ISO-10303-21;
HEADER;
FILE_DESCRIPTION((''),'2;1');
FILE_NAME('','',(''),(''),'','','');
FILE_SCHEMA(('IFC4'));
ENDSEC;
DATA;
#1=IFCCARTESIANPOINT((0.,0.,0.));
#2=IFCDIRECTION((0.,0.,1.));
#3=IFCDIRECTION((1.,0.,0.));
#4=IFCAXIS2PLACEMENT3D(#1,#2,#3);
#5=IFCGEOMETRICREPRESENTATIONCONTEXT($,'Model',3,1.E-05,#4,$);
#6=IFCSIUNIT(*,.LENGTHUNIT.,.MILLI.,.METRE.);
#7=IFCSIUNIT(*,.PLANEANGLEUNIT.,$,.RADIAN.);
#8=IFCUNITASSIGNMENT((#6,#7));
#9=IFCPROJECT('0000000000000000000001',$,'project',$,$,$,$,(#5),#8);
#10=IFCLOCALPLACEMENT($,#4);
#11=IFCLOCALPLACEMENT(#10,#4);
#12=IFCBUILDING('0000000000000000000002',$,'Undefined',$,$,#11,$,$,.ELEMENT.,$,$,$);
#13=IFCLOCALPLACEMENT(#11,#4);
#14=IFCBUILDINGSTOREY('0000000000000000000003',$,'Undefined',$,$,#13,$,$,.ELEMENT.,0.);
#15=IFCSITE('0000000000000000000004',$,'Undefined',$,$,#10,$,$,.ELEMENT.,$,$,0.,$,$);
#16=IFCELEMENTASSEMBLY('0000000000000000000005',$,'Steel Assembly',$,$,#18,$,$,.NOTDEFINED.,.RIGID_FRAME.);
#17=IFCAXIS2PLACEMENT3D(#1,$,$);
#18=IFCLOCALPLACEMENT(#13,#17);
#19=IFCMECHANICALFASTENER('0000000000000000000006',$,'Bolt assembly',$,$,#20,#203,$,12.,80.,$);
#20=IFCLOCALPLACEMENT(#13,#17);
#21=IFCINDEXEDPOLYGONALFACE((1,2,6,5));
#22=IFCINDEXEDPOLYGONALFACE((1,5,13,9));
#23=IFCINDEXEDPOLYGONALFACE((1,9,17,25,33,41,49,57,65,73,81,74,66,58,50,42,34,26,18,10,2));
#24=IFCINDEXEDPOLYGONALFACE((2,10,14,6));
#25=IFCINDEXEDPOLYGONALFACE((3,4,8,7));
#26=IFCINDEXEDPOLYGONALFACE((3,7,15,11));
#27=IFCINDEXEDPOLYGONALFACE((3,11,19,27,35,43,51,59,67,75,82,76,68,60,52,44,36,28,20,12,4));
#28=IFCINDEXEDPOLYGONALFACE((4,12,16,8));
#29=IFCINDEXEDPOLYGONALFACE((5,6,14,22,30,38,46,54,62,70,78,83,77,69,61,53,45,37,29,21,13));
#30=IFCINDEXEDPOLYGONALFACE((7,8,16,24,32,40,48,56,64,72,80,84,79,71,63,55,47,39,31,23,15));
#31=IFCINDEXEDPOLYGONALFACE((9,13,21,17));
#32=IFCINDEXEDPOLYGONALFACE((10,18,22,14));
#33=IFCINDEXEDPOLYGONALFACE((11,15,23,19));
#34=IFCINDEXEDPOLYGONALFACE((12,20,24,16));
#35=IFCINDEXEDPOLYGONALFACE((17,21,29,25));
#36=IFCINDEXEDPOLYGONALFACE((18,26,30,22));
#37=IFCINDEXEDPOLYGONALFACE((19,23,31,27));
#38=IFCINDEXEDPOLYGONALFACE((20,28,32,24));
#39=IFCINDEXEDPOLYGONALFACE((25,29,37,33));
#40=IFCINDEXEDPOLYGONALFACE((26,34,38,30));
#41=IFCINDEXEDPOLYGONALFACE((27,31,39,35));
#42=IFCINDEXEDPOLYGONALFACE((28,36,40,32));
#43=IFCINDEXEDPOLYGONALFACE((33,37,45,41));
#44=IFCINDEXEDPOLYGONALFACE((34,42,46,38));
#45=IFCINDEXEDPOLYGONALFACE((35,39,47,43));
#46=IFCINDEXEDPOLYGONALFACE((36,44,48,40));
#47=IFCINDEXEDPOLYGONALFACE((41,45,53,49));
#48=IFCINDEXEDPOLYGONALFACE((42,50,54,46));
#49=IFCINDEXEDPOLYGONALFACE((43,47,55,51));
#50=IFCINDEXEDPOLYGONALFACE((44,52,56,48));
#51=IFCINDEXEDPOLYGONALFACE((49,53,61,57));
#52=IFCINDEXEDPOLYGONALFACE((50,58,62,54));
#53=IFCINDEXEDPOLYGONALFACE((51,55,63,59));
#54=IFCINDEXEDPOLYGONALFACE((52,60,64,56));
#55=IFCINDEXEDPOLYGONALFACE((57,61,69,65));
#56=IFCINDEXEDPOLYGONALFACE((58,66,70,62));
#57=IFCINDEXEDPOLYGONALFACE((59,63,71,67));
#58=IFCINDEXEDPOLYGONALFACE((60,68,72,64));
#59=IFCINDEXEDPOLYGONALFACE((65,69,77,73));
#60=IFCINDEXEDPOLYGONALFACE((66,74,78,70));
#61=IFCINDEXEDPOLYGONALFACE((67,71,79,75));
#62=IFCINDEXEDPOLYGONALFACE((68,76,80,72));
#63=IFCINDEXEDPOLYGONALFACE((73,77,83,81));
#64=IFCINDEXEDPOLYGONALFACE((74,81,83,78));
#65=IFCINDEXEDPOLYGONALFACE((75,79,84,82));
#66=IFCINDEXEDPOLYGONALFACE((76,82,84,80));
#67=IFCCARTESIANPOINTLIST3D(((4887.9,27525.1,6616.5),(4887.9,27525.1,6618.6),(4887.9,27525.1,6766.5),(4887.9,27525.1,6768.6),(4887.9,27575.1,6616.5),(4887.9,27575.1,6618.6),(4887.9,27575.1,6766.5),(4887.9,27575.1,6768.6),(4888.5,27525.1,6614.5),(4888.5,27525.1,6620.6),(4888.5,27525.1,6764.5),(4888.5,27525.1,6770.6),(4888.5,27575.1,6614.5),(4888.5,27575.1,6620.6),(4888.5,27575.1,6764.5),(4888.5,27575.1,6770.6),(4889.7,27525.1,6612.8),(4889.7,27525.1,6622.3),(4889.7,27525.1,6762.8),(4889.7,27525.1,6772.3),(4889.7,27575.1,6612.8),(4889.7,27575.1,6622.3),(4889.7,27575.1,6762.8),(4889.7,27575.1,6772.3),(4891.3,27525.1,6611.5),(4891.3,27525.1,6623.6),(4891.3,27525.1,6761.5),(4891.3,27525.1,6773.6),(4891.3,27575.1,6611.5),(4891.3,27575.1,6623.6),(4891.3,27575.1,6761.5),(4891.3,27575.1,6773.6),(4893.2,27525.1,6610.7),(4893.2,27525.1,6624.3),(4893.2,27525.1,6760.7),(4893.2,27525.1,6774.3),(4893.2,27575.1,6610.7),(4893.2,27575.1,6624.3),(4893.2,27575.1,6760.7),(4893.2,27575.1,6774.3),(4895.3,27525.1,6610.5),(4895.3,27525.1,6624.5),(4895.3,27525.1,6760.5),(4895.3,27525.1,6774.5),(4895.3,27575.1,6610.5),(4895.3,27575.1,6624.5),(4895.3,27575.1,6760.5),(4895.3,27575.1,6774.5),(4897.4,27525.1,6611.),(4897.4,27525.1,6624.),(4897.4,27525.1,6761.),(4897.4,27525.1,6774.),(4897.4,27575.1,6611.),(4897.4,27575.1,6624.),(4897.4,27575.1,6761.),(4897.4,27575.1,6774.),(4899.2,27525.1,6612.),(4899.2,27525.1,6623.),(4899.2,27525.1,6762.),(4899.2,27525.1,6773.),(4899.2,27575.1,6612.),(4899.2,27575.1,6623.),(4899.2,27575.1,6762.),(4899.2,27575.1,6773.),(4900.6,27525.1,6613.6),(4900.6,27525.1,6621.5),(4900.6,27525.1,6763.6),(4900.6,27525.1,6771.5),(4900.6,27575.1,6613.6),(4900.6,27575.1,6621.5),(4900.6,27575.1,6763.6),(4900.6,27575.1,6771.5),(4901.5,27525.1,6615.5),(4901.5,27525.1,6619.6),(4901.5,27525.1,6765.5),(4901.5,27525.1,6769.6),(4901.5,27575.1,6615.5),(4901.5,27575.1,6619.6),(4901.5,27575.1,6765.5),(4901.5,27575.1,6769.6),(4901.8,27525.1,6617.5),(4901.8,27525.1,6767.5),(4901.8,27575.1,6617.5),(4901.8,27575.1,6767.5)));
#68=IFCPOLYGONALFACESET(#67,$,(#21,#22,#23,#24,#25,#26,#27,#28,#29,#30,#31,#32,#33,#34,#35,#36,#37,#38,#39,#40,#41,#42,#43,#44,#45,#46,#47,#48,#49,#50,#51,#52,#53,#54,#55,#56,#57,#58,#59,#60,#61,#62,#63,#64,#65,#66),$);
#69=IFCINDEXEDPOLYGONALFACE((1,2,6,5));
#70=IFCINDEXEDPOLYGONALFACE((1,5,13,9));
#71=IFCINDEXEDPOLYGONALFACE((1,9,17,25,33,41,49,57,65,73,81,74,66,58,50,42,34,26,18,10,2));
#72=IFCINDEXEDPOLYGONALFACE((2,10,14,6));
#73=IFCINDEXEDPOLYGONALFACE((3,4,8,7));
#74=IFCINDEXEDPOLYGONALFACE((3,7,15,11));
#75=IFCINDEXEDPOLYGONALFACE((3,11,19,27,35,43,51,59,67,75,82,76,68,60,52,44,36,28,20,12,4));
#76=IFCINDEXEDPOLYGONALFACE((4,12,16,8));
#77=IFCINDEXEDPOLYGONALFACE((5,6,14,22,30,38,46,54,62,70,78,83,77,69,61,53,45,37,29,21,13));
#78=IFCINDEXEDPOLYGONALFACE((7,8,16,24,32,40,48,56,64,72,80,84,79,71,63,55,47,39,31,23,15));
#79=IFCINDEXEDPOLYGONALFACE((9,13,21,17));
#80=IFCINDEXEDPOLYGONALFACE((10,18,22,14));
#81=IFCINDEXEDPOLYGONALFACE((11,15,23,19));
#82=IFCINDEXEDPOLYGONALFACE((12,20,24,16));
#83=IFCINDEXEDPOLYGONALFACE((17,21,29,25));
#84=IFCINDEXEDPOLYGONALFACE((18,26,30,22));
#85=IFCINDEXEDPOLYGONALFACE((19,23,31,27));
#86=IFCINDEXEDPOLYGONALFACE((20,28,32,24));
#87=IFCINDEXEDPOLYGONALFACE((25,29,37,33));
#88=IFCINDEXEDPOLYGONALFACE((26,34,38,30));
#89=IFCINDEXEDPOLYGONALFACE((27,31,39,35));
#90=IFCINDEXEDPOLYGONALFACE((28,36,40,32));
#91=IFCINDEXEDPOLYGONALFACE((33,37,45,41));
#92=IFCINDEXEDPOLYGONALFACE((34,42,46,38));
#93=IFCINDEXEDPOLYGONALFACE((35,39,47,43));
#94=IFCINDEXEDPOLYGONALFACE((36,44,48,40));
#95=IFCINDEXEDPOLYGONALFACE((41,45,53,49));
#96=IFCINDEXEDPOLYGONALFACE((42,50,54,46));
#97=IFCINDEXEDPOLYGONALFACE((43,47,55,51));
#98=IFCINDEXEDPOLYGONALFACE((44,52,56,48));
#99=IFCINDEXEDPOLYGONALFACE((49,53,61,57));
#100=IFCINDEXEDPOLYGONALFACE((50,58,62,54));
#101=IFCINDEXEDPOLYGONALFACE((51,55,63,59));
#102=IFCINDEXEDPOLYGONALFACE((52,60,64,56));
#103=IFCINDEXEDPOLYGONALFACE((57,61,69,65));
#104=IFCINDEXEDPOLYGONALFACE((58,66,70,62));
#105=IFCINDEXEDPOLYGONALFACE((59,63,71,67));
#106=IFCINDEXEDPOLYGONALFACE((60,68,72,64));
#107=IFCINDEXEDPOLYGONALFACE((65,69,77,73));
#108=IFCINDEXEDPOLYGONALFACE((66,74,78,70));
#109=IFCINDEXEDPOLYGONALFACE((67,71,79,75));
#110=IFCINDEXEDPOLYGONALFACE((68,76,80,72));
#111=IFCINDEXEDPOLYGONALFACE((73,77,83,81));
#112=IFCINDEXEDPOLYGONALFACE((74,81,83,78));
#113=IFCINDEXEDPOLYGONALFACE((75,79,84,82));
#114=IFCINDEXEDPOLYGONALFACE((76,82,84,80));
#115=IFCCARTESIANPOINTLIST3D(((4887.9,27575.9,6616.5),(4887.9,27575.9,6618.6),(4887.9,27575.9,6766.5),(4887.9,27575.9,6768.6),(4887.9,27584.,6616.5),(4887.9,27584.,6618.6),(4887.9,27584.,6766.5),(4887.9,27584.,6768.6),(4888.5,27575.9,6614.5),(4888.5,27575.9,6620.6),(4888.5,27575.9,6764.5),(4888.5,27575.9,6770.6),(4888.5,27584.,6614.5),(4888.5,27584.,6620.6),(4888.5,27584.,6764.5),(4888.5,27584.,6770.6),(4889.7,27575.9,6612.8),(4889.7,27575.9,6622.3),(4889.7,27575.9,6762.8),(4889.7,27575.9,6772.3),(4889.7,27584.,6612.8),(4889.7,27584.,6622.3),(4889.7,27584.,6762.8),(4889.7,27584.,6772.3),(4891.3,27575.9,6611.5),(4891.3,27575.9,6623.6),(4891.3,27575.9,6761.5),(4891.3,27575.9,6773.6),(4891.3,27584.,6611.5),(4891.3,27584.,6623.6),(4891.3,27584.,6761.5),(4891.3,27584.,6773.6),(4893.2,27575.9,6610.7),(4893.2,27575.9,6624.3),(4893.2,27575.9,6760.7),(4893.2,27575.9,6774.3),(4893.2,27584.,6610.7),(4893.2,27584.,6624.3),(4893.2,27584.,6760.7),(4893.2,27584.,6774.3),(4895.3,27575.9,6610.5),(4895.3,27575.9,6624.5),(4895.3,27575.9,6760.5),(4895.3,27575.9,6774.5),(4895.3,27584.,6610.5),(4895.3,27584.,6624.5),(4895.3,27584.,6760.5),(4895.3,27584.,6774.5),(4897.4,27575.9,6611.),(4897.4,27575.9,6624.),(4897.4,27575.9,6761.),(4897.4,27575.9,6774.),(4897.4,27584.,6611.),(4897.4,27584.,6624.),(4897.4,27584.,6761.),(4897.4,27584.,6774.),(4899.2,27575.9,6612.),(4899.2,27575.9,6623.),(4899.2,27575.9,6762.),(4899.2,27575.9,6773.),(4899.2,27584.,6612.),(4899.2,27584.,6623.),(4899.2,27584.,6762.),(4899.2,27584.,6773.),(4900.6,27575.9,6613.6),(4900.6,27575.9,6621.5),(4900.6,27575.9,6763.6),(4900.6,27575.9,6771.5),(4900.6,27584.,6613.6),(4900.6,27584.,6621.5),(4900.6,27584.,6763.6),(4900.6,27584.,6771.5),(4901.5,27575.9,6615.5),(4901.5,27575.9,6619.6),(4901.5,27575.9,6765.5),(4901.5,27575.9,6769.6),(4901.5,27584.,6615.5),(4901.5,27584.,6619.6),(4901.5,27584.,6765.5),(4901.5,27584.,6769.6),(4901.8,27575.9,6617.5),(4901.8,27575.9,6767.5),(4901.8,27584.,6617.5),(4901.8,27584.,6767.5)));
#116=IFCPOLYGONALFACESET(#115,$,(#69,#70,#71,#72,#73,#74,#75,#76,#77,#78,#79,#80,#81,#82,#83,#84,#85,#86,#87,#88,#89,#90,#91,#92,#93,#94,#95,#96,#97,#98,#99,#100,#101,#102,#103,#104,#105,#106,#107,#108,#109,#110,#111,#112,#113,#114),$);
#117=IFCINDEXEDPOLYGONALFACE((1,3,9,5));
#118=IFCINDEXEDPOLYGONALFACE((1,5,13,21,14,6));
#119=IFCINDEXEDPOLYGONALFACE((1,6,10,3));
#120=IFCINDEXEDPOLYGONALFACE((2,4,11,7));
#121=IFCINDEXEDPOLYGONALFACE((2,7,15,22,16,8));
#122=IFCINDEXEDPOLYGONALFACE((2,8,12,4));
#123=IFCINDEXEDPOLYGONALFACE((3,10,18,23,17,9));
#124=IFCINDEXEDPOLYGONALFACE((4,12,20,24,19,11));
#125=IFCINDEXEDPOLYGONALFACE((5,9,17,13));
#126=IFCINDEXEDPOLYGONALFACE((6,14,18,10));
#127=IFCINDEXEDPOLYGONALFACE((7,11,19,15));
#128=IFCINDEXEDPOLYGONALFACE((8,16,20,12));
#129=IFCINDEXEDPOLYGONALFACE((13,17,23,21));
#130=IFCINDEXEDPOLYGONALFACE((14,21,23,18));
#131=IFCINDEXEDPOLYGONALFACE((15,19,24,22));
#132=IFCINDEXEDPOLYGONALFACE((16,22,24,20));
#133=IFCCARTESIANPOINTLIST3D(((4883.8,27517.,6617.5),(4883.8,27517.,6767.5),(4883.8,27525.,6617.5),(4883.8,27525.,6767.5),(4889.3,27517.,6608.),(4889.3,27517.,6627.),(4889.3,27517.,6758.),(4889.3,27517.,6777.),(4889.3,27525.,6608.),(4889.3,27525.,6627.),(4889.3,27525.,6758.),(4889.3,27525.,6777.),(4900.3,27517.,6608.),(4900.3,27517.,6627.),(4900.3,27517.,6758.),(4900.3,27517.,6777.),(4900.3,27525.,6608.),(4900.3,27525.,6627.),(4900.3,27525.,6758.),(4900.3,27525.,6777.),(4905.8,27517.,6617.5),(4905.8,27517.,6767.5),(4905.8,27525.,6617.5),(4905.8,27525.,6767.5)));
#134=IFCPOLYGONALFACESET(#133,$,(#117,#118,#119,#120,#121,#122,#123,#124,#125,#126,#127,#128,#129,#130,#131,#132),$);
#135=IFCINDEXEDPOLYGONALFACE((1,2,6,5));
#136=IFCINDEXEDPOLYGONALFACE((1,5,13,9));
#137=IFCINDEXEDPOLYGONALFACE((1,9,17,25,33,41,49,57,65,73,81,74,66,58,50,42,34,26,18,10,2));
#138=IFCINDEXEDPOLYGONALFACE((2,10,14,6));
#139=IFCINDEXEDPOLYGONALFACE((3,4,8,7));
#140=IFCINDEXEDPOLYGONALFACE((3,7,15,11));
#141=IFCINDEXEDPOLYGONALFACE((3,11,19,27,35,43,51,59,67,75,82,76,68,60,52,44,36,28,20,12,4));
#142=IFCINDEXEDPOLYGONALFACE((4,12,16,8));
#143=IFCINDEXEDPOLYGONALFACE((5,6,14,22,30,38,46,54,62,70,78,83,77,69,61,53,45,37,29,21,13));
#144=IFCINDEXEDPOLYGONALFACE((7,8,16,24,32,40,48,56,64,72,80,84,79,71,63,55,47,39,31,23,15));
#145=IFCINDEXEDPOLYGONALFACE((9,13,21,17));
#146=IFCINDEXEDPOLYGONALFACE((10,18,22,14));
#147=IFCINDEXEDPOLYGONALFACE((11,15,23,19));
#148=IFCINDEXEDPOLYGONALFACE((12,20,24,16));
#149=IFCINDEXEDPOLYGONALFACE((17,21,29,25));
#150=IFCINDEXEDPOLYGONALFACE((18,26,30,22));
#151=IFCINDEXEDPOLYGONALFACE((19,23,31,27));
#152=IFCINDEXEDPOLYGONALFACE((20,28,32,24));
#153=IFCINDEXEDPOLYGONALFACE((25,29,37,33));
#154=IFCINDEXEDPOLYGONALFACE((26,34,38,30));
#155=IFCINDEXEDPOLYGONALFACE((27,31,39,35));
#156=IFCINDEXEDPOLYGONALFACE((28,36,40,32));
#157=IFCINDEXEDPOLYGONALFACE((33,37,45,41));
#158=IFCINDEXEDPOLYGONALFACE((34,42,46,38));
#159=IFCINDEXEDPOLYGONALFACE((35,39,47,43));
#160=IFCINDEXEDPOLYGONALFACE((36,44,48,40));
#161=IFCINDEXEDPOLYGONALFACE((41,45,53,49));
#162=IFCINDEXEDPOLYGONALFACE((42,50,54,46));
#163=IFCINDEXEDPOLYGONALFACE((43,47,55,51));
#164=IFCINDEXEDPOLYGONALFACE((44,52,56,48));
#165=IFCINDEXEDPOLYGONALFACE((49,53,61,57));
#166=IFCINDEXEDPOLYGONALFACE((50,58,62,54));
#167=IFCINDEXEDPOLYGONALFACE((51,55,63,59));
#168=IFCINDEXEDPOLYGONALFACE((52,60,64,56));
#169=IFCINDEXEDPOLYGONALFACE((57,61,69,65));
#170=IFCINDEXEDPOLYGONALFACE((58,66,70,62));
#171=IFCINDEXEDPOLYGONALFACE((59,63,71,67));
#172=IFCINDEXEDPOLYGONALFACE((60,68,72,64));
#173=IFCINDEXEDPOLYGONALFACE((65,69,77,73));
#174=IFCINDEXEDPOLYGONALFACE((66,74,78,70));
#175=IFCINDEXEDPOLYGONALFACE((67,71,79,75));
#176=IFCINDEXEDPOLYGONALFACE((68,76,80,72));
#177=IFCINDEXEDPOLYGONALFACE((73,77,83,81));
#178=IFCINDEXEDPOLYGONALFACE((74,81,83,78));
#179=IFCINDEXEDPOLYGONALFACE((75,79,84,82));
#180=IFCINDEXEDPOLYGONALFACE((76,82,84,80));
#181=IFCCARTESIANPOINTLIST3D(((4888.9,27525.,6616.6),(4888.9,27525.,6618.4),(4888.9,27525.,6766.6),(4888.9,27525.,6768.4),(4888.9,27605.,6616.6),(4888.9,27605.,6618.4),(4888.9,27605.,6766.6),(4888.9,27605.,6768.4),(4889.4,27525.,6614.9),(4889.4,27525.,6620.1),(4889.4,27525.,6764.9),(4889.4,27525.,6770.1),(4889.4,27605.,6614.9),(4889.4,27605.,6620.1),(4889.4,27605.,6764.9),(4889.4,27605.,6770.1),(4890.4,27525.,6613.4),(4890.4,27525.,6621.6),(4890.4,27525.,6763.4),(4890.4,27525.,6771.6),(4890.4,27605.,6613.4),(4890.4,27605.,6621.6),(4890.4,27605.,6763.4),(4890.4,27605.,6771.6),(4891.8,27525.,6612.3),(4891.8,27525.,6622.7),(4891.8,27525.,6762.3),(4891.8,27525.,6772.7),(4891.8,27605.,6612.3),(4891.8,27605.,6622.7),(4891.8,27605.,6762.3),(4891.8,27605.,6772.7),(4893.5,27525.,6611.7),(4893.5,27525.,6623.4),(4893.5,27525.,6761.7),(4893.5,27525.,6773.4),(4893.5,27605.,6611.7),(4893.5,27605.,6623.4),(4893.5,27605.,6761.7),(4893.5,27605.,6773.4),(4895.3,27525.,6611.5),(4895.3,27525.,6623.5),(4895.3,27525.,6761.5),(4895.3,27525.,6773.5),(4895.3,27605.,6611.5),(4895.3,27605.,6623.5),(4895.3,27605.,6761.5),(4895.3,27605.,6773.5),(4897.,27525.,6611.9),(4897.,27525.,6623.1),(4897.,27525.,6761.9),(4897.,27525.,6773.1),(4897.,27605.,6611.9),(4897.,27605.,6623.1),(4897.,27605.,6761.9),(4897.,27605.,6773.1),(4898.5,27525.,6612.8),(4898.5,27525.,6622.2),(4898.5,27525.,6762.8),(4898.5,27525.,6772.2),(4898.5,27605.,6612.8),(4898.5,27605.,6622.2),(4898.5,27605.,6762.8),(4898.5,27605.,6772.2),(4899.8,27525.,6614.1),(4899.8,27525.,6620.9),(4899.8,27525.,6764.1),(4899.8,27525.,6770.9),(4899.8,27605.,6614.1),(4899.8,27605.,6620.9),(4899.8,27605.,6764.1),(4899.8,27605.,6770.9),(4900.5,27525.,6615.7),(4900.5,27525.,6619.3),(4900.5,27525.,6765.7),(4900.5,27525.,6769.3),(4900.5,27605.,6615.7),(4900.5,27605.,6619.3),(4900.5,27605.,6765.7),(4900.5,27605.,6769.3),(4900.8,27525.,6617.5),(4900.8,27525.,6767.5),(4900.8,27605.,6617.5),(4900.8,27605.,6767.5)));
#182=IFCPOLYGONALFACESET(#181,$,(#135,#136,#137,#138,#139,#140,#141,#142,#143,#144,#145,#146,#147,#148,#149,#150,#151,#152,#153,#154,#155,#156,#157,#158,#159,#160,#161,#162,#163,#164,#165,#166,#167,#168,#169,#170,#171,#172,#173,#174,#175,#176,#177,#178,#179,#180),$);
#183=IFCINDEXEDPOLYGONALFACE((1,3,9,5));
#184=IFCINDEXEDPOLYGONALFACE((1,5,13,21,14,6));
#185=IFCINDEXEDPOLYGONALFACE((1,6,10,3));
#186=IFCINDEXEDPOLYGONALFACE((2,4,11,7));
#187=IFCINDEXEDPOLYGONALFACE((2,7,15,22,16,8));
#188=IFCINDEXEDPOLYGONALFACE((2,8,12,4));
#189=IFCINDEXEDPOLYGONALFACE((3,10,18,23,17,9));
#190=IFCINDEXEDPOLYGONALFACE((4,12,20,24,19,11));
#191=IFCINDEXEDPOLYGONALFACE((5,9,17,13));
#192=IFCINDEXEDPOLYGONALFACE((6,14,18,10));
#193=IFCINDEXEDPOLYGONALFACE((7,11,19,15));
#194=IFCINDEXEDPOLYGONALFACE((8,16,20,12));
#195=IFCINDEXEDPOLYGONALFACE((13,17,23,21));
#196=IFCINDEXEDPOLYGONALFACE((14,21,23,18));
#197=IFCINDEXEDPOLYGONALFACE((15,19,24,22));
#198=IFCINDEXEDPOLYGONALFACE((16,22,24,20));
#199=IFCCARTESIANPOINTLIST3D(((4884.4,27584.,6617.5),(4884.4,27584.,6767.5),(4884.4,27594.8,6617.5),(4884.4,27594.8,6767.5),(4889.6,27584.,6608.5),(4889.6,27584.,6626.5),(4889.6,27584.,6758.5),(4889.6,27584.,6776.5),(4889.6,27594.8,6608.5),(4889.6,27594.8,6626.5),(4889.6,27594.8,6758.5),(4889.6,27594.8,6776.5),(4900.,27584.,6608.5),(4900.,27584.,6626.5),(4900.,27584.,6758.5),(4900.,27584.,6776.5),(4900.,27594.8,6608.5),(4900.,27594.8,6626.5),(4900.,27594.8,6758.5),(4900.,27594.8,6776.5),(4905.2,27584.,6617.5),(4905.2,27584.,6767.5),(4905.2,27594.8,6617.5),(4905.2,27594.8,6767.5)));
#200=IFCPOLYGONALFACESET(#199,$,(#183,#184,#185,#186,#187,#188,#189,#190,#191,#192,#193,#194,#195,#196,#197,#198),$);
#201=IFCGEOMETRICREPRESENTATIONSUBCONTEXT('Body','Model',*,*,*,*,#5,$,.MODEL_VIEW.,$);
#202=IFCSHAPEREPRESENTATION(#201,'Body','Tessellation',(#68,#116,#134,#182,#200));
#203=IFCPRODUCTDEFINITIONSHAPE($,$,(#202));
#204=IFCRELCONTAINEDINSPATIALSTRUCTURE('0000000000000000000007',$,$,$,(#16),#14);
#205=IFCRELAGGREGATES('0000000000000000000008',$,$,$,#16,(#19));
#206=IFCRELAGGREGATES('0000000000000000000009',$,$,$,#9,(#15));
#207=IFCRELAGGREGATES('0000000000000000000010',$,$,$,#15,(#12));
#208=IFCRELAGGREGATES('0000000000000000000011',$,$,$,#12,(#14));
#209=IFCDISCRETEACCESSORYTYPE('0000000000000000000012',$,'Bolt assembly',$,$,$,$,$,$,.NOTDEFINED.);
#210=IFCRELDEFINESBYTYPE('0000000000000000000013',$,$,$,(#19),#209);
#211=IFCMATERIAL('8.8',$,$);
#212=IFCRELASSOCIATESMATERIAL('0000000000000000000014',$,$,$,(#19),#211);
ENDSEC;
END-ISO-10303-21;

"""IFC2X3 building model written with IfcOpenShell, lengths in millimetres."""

from ifc_helpers import new_model, si_unit, frame, origin_with_axes, origin_2d_with_axis, place, context, subcontext, project, spatial, polyline, circle, outline, extrude, source, transform, mapped, material, type_object, element, aggregate, save


model = new_model("IFC2X3")

# Units and contexts
model_context = context("Model", 3, precision=1e-05, world=origin_with_axes())
body_context = subcontext(model_context, "Body", "Model", "MODEL_VIEW")
ifc_project = project(units=[si_unit("LENGTHUNIT", "METRE", prefix="MILLI"), si_unit("PLANEANGLEUNIT", "RADIAN")], contexts=[model_context])

# Site, building, storey
site_placement = place(None, origin_with_axes())
site = spatial("IfcSite", under=ifc_project, at=site_placement, Name="Undefined", CompositionType="ELEMENT", RefElevation=0.0)
building_placement = place(site_placement, origin_with_axes())
building = spatial("IfcBuilding", under=site, at=building_placement, Name="Undefined", CompositionType="ELEMENT")
storey_placement = place(building_placement, origin_with_axes())
storey = spatial("IfcBuildingStorey", under=building, at=storey_placement, Name="Undefined", CompositionType="ELEMENT", Elevation=0.0)

# Element assembly
assembly_1_placement = place(storey_placement, origin_with_axes())
assembly_1 = element("IfcElementAssembly", 1, at=assembly_1_placement, inside=storey, Name="Steel Assembly", AssemblyPlace="NOTDEFINED", PredefinedType="RIGID_FRAME")

# Shared definitions
ifc_material_1 = material(Name="8.8")
discrete_accessory_type_1 = type_object("IfcDiscreteAccessoryType", Name="Bolt assembly")
shared_shape_1 = source(origin_with_axes(), body_context, "Body", "SweptSolid", [
    extrude(circle(Radius=7.0, at=origin_2d_with_axis()), frame((0.0, -52.9, 0.0), z_axis=(0.0, 1.0, 0.0), x_axis=(1.0, 0.0, 0.0)), (0.0, 0.0, 1.0), 50.0),
    extrude(circle(Radius=7.0, at=origin_2d_with_axis()), frame((0.0, -2.1, 0.0), z_axis=(0.0, 1.0, 0.0), x_axis=(1.0, 0.0, 0.0)), (0.0, 0.0, 1.0), 8.1),
    extrude(outline(polyline([(11.0, 0.0), (5.5, 9.5), (-5.5, 9.5), (-11.0, 0.0), (-5.5, -9.5), (5.5, -9.5), (11.0, 0.0)])), frame((0.0, -61.0, 0.0), z_axis=(0.0, 1.0, 0.0), x_axis=(1.0, 0.0, 0.0)), (0.0, 0.0, 1.0), 8.0),
    extrude(circle(Radius=6.0, at=origin_2d_with_axis()), frame((0.0, -53.0, 0.0), z_axis=(0.0, 1.0, 0.0), x_axis=(1.0, 0.0, 0.0)), (0.0, 0.0, 1.0), 80.0),
    extrude(outline(polyline([(10.4, 0.0), (5.2, 9.0), (-5.2, 9.0), (-10.4, 0.0), (-5.2, -9.0), (5.2, -9.0), (10.4, 0.0)])), frame((0.0, 6.0, 0.0), z_axis=(0.0, 1.0, 0.0), x_axis=(1.0, 0.0, 0.0)), (0.0, 0.0, 1.0), 10.8),
])

# Mechanical fastener
mechanical_fastener_1_placement = place(assembly_1_placement, frame((4869.8, 27578.0, 6692.5), z_axis=(0.0, 0.0, 1.0), x_axis=(1.0, 0.0, 0.0)))
mechanical_fastener_1 = element("IfcMechanicalFastener", 2, at=mechanical_fastener_1_placement, type_object=discrete_accessory_type_1, material=ifc_material_1, Name="Bolt assembly", NominalDiameter=12.0, NominalLength=80.0, context=body_context, shape_type="MappedRepresentation", body=[
    mapped(shared_shape_1, transform((25.0, 0.0, -75.0))),
    mapped(shared_shape_1, transform((25.0, 0.0, 75.0))),
])

aggregate(assembly_1, [mechanical_fastener_1])

save(model, "model.ifc")
